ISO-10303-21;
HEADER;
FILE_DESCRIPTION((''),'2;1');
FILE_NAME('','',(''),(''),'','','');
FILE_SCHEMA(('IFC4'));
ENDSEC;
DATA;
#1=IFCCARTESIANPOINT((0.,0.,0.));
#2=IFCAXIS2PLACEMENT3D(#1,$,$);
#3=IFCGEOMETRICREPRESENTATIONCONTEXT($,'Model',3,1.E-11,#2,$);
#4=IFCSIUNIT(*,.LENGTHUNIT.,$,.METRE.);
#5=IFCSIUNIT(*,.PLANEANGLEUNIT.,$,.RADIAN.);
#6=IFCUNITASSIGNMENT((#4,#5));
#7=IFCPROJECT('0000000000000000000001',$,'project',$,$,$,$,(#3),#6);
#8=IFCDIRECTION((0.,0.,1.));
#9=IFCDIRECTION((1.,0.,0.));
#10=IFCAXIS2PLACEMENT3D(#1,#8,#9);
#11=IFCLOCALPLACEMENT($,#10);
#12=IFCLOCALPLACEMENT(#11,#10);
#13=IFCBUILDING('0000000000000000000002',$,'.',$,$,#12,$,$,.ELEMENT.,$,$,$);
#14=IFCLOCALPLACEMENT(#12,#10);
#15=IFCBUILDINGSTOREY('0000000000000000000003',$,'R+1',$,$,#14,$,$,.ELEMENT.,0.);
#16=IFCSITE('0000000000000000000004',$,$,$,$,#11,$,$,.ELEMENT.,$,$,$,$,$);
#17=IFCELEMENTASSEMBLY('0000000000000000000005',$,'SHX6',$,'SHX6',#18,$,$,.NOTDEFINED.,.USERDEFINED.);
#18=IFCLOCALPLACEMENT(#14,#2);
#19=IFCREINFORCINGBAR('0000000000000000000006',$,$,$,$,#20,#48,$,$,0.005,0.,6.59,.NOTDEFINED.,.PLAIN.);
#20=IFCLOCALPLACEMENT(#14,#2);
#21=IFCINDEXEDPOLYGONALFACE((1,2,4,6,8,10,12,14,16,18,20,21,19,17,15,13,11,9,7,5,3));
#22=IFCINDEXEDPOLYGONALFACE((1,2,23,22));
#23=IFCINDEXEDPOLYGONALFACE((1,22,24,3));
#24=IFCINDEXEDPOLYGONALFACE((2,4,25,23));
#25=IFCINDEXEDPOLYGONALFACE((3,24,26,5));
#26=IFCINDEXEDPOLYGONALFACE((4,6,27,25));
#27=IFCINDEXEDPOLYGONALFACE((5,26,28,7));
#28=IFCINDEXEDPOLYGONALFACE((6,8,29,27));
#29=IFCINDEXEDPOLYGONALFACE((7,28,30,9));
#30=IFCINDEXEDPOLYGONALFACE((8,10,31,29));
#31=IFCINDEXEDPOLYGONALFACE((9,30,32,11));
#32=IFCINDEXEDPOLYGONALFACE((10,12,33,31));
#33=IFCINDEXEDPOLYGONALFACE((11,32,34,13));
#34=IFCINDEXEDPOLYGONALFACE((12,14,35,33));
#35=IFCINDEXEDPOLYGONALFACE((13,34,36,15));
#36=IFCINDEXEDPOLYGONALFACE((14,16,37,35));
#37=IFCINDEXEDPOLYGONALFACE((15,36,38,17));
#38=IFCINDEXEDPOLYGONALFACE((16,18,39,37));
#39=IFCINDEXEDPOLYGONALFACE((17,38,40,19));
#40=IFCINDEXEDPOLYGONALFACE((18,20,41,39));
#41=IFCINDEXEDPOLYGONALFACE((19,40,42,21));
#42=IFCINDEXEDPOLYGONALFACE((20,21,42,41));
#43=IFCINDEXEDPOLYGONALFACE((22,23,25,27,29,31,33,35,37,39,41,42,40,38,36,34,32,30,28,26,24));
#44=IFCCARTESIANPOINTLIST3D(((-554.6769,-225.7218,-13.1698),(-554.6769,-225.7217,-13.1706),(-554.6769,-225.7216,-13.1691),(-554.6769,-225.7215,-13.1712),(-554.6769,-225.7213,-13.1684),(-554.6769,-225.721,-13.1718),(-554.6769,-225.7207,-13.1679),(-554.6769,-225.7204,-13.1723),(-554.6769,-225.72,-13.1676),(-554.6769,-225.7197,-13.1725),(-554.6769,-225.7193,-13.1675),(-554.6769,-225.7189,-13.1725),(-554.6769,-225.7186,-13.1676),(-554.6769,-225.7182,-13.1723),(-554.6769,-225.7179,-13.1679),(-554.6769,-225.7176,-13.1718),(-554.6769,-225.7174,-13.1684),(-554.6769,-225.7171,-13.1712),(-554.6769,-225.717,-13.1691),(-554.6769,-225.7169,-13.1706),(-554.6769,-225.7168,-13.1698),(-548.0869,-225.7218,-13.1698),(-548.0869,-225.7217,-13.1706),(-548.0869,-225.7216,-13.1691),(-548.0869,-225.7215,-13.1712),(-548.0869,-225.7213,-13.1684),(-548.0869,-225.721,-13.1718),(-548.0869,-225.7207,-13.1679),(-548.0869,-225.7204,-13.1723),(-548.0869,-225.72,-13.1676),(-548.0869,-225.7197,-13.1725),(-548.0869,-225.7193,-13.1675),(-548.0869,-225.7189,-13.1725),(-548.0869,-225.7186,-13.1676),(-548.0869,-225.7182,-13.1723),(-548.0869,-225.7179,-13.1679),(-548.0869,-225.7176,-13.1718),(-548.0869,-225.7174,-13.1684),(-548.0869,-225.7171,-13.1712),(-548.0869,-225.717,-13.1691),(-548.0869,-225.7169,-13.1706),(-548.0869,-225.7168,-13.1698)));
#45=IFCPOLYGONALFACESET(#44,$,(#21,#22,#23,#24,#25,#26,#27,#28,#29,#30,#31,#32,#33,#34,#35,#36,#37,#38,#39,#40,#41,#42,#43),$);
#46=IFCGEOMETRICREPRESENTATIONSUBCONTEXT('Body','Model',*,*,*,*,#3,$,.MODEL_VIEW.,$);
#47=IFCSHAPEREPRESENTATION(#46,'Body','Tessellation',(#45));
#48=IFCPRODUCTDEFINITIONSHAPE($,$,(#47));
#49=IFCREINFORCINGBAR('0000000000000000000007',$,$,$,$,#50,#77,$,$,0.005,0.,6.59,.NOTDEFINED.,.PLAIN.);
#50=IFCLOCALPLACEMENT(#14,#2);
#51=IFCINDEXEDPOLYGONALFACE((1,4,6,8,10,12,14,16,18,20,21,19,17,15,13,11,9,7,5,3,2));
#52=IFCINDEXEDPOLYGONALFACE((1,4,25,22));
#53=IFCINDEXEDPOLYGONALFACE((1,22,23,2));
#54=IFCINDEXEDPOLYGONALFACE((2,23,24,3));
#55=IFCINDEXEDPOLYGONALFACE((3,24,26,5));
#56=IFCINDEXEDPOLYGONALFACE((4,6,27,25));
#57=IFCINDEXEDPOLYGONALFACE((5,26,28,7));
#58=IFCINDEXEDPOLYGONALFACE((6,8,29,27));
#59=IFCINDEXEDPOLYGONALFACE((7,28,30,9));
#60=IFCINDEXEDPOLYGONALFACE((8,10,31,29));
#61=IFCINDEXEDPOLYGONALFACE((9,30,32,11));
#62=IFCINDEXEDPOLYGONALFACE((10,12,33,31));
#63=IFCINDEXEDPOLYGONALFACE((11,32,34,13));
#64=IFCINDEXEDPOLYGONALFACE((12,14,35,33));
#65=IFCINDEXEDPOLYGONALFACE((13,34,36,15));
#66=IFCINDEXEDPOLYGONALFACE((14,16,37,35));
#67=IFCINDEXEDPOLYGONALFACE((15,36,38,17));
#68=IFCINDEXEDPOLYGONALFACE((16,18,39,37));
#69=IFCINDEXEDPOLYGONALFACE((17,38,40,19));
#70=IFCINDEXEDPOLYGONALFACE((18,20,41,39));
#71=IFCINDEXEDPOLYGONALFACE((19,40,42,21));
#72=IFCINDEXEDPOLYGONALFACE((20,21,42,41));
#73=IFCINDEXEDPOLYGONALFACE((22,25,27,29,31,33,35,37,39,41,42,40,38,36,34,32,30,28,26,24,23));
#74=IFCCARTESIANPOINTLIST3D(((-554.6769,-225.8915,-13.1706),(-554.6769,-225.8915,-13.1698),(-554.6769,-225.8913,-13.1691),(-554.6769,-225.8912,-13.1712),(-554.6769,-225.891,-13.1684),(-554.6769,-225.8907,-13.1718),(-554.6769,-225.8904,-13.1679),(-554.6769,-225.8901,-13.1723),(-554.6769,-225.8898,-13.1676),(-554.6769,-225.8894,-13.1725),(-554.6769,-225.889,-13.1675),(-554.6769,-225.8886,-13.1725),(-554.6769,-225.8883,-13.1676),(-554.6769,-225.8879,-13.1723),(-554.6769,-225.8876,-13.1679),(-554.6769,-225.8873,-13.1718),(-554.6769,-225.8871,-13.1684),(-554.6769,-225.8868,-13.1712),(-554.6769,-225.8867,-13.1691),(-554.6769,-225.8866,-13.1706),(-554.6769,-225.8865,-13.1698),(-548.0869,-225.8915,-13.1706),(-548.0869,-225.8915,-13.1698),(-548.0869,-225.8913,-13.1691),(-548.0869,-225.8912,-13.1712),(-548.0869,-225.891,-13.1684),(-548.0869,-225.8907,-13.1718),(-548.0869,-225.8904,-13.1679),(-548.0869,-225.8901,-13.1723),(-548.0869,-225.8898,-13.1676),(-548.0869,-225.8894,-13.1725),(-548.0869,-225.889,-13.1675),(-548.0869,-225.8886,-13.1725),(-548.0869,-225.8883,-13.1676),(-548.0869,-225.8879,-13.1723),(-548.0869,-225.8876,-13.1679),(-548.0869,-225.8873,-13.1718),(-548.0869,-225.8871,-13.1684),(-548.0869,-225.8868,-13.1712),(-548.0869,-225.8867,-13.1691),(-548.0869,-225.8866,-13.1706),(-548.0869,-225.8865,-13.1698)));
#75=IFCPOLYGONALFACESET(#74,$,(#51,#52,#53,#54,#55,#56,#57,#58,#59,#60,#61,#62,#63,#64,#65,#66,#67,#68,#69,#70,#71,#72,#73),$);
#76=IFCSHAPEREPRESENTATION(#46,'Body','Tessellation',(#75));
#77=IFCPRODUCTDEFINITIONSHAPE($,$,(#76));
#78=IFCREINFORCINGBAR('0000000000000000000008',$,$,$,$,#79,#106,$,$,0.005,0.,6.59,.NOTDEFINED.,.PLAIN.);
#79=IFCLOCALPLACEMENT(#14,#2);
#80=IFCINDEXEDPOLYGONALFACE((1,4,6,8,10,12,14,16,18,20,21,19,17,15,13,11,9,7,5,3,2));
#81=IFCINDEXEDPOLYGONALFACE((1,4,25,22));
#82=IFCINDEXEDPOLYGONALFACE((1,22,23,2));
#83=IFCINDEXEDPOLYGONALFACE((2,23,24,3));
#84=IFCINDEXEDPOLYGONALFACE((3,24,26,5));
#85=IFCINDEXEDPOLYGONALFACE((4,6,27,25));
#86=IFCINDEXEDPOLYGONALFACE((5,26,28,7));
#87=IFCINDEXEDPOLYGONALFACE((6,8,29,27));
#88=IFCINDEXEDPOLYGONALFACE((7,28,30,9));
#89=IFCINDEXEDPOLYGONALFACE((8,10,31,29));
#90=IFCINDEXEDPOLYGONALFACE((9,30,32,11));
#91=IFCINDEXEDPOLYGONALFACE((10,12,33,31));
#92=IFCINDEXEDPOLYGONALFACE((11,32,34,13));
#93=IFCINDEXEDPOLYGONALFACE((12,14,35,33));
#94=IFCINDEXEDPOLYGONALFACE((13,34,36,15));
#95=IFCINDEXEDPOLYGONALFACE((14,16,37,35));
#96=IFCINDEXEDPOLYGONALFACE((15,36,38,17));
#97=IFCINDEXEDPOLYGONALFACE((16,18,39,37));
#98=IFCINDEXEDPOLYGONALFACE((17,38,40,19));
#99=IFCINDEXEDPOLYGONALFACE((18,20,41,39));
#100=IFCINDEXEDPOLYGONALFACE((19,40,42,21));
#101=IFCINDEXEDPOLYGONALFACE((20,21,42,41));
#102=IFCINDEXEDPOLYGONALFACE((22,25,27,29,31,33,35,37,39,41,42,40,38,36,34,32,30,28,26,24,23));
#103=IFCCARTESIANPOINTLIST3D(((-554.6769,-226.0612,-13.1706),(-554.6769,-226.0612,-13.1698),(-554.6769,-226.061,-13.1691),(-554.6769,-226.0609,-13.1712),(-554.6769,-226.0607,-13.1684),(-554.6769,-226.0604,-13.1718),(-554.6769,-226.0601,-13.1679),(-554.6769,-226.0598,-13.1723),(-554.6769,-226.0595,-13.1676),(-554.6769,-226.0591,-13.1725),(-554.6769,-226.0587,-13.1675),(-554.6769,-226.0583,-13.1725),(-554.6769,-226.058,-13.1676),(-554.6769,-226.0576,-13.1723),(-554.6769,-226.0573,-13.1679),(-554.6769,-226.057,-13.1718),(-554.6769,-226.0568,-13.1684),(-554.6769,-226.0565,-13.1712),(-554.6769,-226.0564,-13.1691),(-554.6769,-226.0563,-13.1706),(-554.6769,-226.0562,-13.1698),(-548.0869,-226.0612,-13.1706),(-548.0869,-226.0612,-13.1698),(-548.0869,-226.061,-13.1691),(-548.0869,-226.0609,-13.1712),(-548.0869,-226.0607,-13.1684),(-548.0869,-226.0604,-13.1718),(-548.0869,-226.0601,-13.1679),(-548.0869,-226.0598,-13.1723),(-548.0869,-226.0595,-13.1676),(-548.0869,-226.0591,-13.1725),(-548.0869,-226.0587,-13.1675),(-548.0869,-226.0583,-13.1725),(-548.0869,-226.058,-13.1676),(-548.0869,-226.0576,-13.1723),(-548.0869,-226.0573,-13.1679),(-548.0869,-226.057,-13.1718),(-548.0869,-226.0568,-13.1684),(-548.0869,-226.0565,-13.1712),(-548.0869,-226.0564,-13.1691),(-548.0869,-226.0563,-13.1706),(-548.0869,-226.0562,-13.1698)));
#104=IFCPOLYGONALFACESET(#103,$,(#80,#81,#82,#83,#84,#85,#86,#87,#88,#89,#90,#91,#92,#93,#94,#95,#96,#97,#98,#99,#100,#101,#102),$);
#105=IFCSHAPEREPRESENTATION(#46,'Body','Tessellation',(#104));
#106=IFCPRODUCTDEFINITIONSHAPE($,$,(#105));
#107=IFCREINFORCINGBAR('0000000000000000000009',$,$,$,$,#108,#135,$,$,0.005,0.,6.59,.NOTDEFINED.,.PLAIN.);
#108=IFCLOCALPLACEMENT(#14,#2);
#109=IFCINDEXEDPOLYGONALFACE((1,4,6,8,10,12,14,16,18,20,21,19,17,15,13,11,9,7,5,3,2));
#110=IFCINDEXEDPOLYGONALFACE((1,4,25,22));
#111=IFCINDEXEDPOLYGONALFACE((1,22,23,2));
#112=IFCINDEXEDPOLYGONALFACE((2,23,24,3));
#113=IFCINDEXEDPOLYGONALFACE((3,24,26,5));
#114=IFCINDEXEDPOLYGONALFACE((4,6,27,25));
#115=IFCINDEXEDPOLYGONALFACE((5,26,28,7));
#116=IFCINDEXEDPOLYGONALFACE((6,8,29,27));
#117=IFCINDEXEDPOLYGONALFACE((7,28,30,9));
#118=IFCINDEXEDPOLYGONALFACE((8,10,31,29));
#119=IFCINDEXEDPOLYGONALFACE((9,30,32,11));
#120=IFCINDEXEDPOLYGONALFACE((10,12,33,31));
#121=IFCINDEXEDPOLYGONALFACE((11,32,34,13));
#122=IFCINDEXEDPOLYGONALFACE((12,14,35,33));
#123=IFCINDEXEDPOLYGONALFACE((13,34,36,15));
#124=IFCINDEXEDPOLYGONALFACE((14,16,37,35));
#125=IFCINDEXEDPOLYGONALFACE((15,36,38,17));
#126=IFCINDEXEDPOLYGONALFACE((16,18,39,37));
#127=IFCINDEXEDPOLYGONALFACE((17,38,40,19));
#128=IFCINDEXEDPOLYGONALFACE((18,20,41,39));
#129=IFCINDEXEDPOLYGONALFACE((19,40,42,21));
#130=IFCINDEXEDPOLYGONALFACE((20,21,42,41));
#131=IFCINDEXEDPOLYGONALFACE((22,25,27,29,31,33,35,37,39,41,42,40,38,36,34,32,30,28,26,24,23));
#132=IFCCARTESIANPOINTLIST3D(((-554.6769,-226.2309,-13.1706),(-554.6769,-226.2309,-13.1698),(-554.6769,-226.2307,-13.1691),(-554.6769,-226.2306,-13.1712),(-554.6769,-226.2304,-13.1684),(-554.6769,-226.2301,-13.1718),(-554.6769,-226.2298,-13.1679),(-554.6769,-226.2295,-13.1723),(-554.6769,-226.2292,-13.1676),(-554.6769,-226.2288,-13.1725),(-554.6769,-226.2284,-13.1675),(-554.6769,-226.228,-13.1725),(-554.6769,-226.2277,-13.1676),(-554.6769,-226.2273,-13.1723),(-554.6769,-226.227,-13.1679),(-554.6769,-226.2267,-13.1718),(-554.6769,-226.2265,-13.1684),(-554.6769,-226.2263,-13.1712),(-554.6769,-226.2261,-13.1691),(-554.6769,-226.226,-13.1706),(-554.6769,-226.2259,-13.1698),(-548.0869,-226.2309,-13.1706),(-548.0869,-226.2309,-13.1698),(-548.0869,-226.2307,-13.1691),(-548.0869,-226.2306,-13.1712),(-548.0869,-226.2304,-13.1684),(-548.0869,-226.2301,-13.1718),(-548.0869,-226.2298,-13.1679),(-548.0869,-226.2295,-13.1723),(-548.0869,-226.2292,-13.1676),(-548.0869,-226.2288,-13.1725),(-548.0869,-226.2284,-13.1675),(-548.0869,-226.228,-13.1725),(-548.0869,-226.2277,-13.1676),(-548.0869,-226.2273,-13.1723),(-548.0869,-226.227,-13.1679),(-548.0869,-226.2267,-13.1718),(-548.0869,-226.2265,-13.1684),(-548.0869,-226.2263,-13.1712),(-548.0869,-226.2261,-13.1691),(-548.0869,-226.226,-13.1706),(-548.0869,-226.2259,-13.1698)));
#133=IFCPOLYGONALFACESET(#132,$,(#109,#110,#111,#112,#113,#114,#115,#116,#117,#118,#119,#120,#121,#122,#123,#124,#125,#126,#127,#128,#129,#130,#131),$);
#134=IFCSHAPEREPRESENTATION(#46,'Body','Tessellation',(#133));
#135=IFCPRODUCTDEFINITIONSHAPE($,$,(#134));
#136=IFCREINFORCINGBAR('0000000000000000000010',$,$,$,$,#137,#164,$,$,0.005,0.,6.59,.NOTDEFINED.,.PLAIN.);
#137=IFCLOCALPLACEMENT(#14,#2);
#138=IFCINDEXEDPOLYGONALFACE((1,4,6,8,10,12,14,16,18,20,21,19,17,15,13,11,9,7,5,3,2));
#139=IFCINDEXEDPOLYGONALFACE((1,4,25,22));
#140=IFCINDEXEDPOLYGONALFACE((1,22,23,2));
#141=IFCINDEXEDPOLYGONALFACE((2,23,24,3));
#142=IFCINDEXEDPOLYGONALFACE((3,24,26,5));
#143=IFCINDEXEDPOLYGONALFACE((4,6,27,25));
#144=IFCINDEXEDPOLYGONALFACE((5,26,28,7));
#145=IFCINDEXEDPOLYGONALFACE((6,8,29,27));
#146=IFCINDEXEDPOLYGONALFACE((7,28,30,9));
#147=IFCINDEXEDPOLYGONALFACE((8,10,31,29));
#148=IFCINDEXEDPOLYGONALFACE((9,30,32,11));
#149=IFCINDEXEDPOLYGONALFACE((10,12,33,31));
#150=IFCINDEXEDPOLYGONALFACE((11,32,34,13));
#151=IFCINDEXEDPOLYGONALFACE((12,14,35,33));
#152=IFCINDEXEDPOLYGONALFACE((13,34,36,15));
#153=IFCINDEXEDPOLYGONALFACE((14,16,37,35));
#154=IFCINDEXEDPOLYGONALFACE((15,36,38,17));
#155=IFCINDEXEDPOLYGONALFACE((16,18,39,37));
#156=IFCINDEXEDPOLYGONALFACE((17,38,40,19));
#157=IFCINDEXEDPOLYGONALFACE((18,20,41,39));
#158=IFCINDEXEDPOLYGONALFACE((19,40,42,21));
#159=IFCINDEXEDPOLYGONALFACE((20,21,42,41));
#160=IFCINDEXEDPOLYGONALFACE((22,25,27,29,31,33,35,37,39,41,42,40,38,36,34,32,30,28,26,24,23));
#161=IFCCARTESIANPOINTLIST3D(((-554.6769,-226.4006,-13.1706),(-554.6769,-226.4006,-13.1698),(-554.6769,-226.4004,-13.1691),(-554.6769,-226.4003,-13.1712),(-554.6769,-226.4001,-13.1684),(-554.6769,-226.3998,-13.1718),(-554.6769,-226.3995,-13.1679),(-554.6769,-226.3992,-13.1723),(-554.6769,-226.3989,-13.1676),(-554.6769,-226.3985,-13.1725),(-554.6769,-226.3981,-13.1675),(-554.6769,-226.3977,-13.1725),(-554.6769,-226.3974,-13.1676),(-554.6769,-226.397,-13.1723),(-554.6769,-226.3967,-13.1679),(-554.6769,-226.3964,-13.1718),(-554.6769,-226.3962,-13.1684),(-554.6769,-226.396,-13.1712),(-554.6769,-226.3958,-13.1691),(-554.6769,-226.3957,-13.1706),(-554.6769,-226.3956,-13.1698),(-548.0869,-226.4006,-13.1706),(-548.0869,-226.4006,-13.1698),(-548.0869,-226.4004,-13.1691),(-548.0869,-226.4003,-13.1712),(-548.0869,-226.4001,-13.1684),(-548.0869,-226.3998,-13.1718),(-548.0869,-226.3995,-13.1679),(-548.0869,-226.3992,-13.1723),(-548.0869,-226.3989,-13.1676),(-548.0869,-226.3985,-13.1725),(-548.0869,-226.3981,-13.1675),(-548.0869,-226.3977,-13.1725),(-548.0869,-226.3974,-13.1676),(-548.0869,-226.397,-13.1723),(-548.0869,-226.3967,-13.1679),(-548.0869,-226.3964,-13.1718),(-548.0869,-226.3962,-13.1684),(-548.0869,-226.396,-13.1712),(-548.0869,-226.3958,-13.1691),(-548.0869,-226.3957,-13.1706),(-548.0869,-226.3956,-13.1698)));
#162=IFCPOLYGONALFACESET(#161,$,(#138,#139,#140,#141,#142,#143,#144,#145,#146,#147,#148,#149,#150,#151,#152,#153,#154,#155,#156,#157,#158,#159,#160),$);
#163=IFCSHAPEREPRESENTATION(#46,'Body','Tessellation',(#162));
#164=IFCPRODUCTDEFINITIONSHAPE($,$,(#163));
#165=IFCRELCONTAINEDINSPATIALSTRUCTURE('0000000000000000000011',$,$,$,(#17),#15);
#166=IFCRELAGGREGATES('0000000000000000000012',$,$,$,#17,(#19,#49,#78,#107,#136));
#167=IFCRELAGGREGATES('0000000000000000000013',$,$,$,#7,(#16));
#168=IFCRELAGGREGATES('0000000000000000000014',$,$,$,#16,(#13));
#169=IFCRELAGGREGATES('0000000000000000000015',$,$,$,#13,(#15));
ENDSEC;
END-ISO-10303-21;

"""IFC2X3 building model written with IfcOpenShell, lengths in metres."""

from ifc_helpers import new_model, entity, si_unit, origin, origin_with_axes, place, context, subcontext, project, spatial, shape, element, aggregate, save


model = new_model("IFC2X3")

# Units and contexts
model_context = context("Model", 3, precision=1e-11, world=origin())
body_context = subcontext(model_context, "Body", "Model", "MODEL_VIEW")
ifc_project = project(units=[si_unit("LENGTHUNIT", "METRE"), si_unit("PLANEANGLEUNIT", "RADIAN")], contexts=[model_context])

# Site, building, storey
site_placement = place(None, origin_with_axes())
site = spatial("IfcSite", under=ifc_project, at=site_placement, CompositionType="ELEMENT")
building_placement = place(site_placement, origin_with_axes())
building = spatial("IfcBuilding", under=site, at=building_placement, Name=".", CompositionType="ELEMENT")
storey_placement = place(building_placement, origin_with_axes())
storey = spatial("IfcBuildingStorey", under=building, at=storey_placement, Name="R+1", CompositionType="ELEMENT", Elevation=0.0)

# Element assembly, reinforcing bars
assembly_1_placement = place(storey_placement, origin_with_axes())
assembly_1 = element("IfcElementAssembly", 1, at=assembly_1_placement, inside=storey, Name="SHX6", ObjectType="SHX6", AssemblyPlace="NOTDEFINED", PredefinedType="USERDEFINED")
reinforcing_bar_1_placement = place(assembly_1_placement, origin_with_axes())
reinforcing_bar_1 = element("IfcReinforcingBar", 2, at=reinforcing_bar_1_placement, BarLength=6.59, BarRole="NOTDEFINED", BarSurface="PLAIN", CrossSectionArea=0.0, NominalDiameter=0.005, shapes=[
    shape(body_context, "Body", "AdvancedSweptSolid", [entity("IfcSweptDiskSolid", entity("IfcPolyline", [entity("IfcCartesianPoint", [548.0869, 225.7193, 13.17]), entity("IfcCartesianPoint", [554.6769, 225.7193, 13.17])]), 0.0025, None, 0.0, 6.59)]),
    shape(body_context, "Body", "AdvancedSweptSolid", [entity("IfcSweptDiskSolid", entity("IfcPolyline", [entity("IfcCartesianPoint", [548.0869, 225.7193, 13.17]), entity("IfcCartesianPoint", [554.6769, 225.7193, 13.17])]), 0.0025, None, 0.0, 6.59)]),
])
reinforcing_bar_2_placement = place(assembly_1_placement, origin_with_axes())
reinforcing_bar_2 = element("IfcReinforcingBar", 3, at=reinforcing_bar_2_placement, BarLength=6.59, BarRole="NOTDEFINED", BarSurface="PLAIN", CrossSectionArea=0.0, NominalDiameter=0.005, shapes=[
    shape(body_context, "Body", "AdvancedSweptSolid", [entity("IfcSweptDiskSolid", entity("IfcPolyline", [entity("IfcCartesianPoint", [548.0869, 225.889, 13.17]), entity("IfcCartesianPoint", [554.6769, 225.889, 13.17])]), 0.0025, None, 0.0, 6.59)]),
    shape(body_context, "Body", "AdvancedSweptSolid", [entity("IfcSweptDiskSolid", entity("IfcPolyline", [entity("IfcCartesianPoint", [548.0869, 225.889, 13.17]), entity("IfcCartesianPoint", [554.6769, 225.889, 13.17])]), 0.0025, None, 0.0, 6.59)]),
])
reinforcing_bar_3_placement = place(assembly_1_placement, origin_with_axes())
reinforcing_bar_3 = element("IfcReinforcingBar", 4, at=reinforcing_bar_3_placement, BarLength=6.59, BarRole="NOTDEFINED", BarSurface="PLAIN", CrossSectionArea=0.0, NominalDiameter=0.005, shapes=[
    shape(body_context, "Body", "AdvancedSweptSolid", [entity("IfcSweptDiskSolid", entity("IfcPolyline", [entity("IfcCartesianPoint", [548.0869, 226.0587, 13.17]), entity("IfcCartesianPoint", [554.6769, 226.0587, 13.17])]), 0.0025, None, 0.0, 6.59)]),
    shape(body_context, "Body", "AdvancedSweptSolid", [entity("IfcSweptDiskSolid", entity("IfcPolyline", [entity("IfcCartesianPoint", [548.0869, 226.0587, 13.17]), entity("IfcCartesianPoint", [554.6769, 226.0587, 13.17])]), 0.0025, None, 0.0, 6.59)]),
])
reinforcing_bar_4_placement = place(assembly_1_placement, origin_with_axes())
reinforcing_bar_4 = element("IfcReinforcingBar", 5, at=reinforcing_bar_4_placement, BarLength=6.59, BarRole="NOTDEFINED", BarSurface="PLAIN", CrossSectionArea=0.0, NominalDiameter=0.005, shapes=[
    shape(body_context, "Body", "AdvancedSweptSolid", [entity("IfcSweptDiskSolid", entity("IfcPolyline", [entity("IfcCartesianPoint", [548.0869, 226.2284, 13.17]), entity("IfcCartesianPoint", [554.6769, 226.2284, 13.17])]), 0.0025, None, 0.0, 6.59)]),
    shape(body_context, "Body", "AdvancedSweptSolid", [entity("IfcSweptDiskSolid", entity("IfcPolyline", [entity("IfcCartesianPoint", [548.0869, 226.2284, 13.17]), entity("IfcCartesianPoint", [554.6769, 226.2284, 13.17])]), 0.0025, None, 0.0, 6.59)]),
])
reinforcing_bar_5_placement = place(assembly_1_placement, origin_with_axes())
reinforcing_bar_5 = element("IfcReinforcingBar", 6, at=reinforcing_bar_5_placement, BarLength=6.59, BarRole="NOTDEFINED", BarSurface="PLAIN", CrossSectionArea=0.0, NominalDiameter=0.005, shapes=[
    shape(body_context, "Body", "AdvancedSweptSolid", [entity("IfcSweptDiskSolid", entity("IfcPolyline", [entity("IfcCartesianPoint", [548.0869, 226.3981, 13.17]), entity("IfcCartesianPoint", [554.6769, 226.3981, 13.17])]), 0.0025, None, 0.0, 6.59)]),
    shape(body_context, "Body", "AdvancedSweptSolid", [entity("IfcSweptDiskSolid", entity("IfcPolyline", [entity("IfcCartesianPoint", [548.0869, 226.3981, 13.17]), entity("IfcCartesianPoint", [554.6769, 226.3981, 13.17])]), 0.0025, None, 0.0, 6.59)]),
])
aggregate(assembly_1, [reinforcing_bar_1, reinforcing_bar_2, reinforcing_bar_3, reinforcing_bar_4, reinforcing_bar_5])

save(model, "model.ifc")
